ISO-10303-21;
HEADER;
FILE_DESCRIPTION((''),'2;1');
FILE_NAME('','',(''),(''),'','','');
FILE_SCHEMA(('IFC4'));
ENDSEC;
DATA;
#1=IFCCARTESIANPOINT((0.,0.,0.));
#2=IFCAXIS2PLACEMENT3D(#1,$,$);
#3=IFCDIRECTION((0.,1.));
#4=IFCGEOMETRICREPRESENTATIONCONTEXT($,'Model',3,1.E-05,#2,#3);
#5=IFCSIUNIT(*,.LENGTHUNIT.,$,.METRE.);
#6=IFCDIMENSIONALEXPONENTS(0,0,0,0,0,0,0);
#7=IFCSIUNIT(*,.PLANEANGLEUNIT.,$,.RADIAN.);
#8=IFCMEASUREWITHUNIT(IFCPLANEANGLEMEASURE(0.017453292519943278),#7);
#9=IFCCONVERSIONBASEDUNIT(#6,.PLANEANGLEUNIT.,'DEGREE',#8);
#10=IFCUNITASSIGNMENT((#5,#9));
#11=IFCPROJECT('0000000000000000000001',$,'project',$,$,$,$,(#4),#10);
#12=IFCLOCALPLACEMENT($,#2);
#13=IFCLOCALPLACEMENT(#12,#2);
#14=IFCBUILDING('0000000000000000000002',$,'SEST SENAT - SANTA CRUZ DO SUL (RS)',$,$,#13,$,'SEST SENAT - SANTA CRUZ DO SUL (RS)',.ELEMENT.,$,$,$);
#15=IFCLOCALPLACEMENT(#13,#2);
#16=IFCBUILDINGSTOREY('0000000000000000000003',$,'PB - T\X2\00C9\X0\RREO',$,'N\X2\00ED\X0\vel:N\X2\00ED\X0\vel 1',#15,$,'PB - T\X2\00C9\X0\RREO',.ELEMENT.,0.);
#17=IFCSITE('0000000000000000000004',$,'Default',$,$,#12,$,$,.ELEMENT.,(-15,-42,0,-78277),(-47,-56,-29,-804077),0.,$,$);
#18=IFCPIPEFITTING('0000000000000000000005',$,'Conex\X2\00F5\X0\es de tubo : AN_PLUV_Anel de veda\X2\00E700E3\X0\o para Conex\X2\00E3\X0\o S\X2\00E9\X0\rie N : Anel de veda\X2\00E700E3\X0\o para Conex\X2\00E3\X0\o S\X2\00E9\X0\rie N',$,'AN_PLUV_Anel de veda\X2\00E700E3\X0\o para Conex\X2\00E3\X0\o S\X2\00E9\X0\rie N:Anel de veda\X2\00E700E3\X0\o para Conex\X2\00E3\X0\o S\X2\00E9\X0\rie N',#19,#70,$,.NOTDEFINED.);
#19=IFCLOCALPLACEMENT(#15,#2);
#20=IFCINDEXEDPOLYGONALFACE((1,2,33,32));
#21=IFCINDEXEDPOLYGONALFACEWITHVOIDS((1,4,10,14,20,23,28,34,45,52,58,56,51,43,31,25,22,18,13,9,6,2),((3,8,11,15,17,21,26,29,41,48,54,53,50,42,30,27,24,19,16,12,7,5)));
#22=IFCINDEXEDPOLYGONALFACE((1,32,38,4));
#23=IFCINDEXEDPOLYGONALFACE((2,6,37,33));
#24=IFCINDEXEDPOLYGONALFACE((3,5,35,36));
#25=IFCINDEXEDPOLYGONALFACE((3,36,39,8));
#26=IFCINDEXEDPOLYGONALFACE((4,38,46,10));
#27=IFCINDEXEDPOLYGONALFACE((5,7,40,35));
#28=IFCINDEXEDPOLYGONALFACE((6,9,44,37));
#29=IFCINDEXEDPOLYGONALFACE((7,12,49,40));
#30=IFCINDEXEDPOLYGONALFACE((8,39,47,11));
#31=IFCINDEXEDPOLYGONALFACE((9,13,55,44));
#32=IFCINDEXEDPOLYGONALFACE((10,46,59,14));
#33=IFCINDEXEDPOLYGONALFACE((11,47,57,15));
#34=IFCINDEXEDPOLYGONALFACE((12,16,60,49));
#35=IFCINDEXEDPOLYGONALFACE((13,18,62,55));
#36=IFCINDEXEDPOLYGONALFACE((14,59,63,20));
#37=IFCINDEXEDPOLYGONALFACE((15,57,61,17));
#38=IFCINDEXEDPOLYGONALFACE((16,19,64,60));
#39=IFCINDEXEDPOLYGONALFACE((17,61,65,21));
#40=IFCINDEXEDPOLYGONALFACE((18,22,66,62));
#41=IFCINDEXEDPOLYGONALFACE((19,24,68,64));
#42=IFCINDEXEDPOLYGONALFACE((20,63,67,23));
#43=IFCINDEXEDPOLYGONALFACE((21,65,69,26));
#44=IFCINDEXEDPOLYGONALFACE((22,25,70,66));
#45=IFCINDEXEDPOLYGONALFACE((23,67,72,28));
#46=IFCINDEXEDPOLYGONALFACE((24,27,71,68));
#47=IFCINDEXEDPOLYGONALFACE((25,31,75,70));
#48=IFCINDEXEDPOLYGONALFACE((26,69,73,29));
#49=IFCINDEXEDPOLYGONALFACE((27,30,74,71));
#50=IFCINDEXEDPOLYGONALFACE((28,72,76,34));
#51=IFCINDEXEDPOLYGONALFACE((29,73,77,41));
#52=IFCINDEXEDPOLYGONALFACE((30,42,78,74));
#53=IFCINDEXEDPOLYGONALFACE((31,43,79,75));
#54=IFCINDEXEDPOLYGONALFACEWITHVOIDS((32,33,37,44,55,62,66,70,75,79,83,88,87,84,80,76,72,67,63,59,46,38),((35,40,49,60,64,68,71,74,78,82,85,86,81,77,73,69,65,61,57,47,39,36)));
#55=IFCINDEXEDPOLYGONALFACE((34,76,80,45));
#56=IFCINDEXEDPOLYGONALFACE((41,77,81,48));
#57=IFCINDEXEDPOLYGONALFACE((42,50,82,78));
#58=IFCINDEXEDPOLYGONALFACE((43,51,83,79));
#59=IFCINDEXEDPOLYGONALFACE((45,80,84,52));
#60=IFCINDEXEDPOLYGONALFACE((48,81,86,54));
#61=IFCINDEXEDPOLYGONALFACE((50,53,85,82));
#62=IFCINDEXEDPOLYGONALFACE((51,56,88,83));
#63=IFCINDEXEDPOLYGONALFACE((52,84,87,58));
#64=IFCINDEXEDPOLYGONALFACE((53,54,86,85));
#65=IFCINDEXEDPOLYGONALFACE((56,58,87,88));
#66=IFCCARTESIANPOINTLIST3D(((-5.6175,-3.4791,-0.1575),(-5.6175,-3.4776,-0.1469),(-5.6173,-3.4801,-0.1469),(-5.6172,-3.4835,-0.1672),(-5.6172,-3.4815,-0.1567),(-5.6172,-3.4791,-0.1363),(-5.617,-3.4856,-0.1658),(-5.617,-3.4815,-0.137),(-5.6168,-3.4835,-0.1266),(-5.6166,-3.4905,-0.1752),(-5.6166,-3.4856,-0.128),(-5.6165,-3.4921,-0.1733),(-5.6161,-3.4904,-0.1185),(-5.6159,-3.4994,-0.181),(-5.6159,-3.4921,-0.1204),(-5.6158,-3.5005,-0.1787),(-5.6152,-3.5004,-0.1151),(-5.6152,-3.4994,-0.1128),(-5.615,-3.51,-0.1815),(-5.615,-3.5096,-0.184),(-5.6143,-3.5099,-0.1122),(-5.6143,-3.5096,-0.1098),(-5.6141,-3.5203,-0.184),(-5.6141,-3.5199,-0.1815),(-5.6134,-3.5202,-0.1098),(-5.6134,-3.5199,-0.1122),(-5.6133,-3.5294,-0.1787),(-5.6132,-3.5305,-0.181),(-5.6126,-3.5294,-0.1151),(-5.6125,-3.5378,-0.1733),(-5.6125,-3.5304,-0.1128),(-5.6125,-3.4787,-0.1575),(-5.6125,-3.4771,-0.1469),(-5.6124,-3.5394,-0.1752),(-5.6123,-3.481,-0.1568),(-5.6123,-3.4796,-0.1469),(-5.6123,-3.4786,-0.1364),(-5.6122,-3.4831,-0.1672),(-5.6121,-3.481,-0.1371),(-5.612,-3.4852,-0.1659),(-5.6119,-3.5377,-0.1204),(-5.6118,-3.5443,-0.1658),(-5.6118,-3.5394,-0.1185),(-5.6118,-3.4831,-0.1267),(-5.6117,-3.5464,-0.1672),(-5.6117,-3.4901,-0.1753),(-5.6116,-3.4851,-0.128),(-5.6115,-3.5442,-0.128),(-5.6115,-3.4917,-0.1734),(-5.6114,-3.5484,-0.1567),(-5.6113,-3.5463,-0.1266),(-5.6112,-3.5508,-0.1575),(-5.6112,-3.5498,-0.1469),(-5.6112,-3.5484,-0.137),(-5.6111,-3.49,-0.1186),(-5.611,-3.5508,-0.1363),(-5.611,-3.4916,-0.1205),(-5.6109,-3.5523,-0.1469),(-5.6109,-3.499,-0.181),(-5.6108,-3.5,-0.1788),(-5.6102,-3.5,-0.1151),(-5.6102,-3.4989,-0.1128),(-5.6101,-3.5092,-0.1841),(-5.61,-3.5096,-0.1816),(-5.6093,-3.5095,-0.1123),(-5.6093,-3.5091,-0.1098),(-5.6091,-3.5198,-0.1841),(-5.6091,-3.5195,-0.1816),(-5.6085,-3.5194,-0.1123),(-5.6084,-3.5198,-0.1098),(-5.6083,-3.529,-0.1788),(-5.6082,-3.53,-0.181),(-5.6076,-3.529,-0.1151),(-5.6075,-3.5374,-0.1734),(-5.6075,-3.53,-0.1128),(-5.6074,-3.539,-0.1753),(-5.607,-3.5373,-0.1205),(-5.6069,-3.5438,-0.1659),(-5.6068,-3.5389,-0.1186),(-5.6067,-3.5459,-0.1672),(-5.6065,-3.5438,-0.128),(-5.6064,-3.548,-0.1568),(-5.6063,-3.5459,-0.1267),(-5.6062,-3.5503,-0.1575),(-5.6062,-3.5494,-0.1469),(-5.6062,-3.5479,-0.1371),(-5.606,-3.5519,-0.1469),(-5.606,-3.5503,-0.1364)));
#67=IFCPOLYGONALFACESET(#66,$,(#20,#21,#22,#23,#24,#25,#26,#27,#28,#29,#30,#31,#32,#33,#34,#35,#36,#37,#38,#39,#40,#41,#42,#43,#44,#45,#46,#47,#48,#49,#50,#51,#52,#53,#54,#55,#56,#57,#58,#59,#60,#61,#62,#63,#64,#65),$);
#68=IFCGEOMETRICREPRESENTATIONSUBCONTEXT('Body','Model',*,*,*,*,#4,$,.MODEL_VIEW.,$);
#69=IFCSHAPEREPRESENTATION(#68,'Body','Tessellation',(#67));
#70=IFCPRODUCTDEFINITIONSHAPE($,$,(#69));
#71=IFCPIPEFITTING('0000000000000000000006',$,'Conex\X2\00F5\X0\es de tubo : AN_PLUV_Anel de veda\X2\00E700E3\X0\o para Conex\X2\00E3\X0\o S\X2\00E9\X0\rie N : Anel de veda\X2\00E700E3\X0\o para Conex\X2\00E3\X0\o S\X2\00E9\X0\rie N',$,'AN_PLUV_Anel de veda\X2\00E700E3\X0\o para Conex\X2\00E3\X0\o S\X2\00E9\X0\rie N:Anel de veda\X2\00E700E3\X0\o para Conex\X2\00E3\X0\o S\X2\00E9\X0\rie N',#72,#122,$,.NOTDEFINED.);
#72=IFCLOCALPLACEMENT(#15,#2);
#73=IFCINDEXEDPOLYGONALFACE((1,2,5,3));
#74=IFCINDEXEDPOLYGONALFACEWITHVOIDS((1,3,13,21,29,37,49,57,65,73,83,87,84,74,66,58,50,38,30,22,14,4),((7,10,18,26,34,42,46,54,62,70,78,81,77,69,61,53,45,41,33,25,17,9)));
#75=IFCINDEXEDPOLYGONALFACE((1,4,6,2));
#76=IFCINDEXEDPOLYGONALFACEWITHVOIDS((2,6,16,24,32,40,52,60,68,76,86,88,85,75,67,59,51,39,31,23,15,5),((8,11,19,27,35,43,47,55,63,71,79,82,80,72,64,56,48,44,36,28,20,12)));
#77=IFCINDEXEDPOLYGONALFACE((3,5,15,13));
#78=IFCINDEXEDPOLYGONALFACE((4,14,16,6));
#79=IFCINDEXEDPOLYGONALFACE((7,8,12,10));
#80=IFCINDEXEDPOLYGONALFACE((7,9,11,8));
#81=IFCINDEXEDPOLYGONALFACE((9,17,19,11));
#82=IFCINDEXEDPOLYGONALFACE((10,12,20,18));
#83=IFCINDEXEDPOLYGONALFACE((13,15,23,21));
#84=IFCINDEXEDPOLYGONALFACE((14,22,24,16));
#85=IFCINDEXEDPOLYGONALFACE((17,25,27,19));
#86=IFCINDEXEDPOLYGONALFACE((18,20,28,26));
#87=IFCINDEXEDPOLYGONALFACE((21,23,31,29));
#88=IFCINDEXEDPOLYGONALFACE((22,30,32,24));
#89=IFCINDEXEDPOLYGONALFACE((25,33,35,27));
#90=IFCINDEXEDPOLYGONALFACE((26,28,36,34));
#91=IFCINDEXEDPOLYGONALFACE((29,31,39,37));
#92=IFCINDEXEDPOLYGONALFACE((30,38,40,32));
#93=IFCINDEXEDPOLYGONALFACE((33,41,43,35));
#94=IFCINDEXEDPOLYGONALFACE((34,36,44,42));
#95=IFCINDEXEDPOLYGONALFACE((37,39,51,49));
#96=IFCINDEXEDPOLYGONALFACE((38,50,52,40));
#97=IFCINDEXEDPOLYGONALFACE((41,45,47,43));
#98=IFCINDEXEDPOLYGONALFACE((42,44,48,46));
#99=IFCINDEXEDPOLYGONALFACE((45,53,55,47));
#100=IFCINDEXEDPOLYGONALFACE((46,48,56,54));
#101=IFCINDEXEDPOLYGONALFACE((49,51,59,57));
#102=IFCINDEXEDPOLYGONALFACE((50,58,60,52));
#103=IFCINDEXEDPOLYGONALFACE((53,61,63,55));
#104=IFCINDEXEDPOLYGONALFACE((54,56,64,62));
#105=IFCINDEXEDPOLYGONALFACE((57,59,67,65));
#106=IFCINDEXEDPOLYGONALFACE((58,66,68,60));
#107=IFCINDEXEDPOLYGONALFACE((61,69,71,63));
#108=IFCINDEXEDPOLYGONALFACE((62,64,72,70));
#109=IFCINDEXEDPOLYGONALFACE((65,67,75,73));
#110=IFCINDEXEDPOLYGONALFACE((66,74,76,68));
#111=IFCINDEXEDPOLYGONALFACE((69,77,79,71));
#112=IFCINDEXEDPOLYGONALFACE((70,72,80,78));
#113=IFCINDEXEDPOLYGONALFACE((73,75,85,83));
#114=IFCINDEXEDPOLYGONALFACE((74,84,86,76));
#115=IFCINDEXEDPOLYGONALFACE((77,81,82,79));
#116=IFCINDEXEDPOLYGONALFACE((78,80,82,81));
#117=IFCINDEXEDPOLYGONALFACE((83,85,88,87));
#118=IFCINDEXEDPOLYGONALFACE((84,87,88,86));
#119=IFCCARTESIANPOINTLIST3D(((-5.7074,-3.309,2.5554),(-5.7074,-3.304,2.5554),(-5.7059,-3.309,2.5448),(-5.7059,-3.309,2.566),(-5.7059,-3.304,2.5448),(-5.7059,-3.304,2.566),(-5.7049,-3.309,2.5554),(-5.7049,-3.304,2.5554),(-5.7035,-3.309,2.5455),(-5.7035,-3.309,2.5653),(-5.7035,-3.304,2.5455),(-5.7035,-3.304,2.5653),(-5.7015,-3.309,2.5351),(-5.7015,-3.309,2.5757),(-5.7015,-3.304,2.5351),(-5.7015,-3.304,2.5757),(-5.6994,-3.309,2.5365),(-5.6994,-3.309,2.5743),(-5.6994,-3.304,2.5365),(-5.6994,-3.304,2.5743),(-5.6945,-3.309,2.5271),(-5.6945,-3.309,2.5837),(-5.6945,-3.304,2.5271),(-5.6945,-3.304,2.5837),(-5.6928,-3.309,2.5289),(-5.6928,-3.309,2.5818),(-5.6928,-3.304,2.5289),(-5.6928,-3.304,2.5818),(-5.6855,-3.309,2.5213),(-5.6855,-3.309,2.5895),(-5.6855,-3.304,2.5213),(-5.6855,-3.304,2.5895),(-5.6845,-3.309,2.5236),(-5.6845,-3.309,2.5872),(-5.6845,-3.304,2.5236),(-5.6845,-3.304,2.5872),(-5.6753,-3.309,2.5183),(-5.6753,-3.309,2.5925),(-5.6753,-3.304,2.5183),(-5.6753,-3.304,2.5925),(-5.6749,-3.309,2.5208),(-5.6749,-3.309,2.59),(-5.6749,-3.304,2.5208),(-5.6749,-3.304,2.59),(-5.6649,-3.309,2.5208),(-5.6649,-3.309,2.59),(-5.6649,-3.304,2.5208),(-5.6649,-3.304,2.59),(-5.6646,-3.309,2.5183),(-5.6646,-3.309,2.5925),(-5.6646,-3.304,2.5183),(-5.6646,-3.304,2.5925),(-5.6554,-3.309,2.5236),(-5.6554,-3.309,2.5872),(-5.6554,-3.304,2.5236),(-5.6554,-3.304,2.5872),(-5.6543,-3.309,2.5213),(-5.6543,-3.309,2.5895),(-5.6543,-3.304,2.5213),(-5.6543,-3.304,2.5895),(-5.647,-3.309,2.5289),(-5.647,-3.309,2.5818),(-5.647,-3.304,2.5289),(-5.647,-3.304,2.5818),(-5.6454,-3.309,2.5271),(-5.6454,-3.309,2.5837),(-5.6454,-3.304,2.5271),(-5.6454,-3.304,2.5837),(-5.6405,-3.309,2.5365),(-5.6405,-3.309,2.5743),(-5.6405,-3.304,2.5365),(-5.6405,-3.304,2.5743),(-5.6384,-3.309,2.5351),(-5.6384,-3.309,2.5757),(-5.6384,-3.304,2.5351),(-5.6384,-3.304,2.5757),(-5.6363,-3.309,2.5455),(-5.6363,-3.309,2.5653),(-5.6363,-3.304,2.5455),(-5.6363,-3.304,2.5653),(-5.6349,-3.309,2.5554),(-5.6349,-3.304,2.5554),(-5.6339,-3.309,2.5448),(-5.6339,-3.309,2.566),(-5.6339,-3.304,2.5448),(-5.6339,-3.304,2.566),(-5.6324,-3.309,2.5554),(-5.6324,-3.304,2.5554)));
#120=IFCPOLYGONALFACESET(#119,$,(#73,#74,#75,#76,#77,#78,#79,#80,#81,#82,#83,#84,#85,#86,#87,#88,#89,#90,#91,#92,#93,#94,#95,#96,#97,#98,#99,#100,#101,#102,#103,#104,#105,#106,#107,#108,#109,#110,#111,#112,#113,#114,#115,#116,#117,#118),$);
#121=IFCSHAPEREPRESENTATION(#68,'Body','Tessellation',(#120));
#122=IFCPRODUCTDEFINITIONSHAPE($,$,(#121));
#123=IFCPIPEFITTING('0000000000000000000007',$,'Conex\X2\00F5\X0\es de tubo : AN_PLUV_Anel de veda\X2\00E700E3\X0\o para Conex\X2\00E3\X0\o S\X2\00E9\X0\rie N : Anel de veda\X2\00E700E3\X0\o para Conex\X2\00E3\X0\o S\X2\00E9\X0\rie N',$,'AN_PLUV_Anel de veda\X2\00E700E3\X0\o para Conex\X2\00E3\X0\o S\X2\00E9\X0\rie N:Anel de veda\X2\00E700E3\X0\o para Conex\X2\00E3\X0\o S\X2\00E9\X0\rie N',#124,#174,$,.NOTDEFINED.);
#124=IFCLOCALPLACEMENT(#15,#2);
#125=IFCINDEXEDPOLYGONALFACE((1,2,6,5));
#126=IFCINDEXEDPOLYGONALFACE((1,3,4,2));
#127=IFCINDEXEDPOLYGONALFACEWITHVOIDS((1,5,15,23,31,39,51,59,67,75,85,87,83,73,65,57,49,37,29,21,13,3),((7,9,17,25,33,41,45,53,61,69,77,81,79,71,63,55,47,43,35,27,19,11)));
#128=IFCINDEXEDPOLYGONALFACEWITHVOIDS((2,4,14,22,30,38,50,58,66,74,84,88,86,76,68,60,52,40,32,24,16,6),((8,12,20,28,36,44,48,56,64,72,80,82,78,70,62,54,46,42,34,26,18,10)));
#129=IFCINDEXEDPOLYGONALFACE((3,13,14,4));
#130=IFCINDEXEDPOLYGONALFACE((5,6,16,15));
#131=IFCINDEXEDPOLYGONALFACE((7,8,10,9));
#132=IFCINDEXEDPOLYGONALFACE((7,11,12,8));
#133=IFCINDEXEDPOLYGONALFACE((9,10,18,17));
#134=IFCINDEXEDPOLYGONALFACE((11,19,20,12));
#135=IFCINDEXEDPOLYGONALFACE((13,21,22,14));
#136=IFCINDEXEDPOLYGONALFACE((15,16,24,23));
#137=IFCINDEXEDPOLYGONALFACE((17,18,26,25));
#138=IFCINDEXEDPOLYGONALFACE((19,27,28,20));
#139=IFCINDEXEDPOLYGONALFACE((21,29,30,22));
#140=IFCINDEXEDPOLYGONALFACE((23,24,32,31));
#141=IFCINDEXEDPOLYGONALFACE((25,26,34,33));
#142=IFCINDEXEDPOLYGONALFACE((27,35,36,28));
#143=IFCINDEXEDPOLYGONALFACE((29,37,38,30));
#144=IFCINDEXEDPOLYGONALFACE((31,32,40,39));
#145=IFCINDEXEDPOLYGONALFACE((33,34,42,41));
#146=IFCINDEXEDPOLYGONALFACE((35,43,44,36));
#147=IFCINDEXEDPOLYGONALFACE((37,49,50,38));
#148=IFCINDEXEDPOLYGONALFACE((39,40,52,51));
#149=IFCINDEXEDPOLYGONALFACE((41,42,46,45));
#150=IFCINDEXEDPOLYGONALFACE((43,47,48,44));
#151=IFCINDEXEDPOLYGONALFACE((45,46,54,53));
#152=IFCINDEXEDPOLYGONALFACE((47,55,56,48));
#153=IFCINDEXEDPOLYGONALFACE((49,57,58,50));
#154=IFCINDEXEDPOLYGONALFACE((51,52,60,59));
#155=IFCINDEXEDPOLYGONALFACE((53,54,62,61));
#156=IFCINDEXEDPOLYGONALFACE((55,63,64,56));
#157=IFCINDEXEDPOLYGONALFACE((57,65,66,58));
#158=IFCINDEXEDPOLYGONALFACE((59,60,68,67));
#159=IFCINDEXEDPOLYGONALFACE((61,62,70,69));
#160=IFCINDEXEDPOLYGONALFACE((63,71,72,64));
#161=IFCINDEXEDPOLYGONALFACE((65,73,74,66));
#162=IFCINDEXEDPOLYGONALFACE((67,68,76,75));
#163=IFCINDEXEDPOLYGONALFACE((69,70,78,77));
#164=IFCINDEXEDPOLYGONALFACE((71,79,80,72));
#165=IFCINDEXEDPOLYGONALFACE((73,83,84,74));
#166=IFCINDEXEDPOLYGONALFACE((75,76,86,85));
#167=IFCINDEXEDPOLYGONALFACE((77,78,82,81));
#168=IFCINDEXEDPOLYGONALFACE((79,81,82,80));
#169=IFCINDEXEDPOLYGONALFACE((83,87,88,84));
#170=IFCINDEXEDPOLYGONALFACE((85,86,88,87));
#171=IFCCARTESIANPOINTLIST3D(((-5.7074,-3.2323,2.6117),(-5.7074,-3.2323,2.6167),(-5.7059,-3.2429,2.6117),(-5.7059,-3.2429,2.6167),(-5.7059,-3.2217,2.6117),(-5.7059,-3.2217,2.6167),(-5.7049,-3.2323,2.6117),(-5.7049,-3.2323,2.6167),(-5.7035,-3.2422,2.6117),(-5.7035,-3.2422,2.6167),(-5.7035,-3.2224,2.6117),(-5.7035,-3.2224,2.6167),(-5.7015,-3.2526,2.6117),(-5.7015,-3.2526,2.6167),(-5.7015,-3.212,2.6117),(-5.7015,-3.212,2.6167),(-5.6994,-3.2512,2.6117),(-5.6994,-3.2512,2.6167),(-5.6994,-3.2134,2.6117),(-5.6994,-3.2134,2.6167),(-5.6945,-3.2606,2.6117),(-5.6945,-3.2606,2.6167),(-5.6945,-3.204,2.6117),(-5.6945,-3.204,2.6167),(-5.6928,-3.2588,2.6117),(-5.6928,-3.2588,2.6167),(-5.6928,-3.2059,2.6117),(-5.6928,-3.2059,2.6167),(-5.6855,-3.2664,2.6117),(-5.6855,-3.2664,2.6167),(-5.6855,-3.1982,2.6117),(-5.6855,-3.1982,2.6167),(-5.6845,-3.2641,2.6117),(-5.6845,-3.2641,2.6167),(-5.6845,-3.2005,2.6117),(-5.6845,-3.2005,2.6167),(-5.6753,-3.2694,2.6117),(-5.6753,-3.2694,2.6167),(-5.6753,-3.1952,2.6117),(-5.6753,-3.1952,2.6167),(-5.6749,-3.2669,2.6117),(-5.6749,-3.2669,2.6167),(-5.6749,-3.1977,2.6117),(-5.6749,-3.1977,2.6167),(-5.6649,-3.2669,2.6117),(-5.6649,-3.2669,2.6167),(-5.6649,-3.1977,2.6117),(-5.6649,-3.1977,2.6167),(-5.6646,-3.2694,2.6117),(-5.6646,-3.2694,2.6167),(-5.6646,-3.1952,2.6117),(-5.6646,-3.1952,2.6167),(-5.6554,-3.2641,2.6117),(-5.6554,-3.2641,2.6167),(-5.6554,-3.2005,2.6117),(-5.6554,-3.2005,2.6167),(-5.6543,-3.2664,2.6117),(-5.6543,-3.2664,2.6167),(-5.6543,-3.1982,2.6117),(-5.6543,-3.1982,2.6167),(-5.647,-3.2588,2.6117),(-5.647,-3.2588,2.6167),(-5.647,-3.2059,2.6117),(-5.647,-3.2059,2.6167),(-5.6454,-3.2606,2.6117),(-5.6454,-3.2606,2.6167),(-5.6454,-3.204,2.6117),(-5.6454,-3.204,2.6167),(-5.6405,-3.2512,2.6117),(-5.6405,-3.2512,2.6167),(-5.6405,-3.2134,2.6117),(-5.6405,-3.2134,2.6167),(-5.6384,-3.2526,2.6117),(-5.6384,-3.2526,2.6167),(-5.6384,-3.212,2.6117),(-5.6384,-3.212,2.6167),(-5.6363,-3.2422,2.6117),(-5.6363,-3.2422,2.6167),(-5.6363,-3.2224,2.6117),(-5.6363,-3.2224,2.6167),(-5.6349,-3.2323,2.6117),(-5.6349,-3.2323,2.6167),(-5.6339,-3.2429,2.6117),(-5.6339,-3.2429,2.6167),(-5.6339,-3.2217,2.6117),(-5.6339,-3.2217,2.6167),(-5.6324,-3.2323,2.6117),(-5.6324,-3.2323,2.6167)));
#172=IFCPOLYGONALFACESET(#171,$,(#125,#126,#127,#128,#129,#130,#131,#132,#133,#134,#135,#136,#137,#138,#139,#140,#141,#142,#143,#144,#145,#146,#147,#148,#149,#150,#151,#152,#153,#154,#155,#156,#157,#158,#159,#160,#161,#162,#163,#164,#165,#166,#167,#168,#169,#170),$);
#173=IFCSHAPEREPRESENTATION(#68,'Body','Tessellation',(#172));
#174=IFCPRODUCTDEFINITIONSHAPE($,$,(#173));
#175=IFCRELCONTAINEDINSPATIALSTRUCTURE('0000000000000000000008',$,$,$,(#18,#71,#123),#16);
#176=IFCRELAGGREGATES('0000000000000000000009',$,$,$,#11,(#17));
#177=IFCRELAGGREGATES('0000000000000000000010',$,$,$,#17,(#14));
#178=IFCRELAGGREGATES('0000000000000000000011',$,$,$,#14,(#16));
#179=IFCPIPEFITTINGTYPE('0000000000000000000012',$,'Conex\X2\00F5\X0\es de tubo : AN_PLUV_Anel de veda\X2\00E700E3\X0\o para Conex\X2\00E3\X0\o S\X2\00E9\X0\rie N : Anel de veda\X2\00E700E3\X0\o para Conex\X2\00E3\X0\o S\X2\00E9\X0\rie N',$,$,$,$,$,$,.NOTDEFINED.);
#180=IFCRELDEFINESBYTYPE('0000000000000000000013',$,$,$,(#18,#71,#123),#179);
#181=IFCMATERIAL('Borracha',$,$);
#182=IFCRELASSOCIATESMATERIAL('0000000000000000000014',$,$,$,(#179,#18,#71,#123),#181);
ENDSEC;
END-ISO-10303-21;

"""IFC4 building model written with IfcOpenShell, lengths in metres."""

from ifc_helpers import new_model, entity, si_unit, converted_unit, direction, frame, origin, place, context, subcontext, project, spatial, arc, indexed_curve, outline, extrude, source, transform, mapped, material, type_object, type_shapes, element, save


model = new_model("IFC4")

# Units and contexts
model_context = context("Model", 3, precision=1e-05, world=origin(), true_north=direction((0.0, 1.0)))
body_context = subcontext(model_context, "Body", "Model", "MODEL_VIEW")
ifc_project = project(units=[si_unit("LENGTHUNIT", "METRE"), converted_unit("PLANEANGLEUNIT", "DEGREE", entity("IfcPlaneAngleMeasure", 0.017453292519943278), si_unit("PLANEANGLEUNIT", "RADIAN"), dimensions=[0, 0, 0, 0, 0, 0, 0])], contexts=[model_context])

# Site, building, storey
site_placement = place(None, origin())
site = spatial("IfcSite", under=ifc_project, at=site_placement, Name="Default", CompositionType="ELEMENT", RefLatitude=(-15, -42, 0, -78277), RefLongitude=(-47, -56, -29, -804077), RefElevation=0.0)
building_placement = place(site_placement, origin())
building = spatial("IfcBuilding", under=site, at=building_placement, Name="SEST SENAT - SANTA CRUZ DO SUL (RS)", LongName="SEST SENAT - SANTA CRUZ DO SUL (RS)", CompositionType="ELEMENT")
storey_placement = place(building_placement, origin())
storey = spatial("IfcBuildingStorey", under=building, at=storey_placement, Name="PB - TÉRREO", ObjectType="Nível:Nível 1", LongName="PB - TÉRREO", CompositionType="ELEMENT", Elevation=0.0)

# Shared definitions
ifc_material_1 = material(Name="Borracha")

# Pipe fittings
pipe_fitting_type_1 = type_object("IfcPipeFittingType", Name="Conexões de tubo : AN_PLUV_Anel de vedação para Conexão Série N : Anel de vedação para Conexão Série N", PredefinedType="NOTDEFINED", material=ifc_material_1)
shared_shape_1 = source(origin(), body_context, "Body", "SweptSolid", [
    extrude(outline(indexed_curve([(-0.0375, 0.0), (0.0, -0.0375), (0.0375, 0.0), (0.0, 0.0375)], segments=[arc(1, 2, 3), arc(3, 4, 1)], self_intersect=False), holes=[indexed_curve([(-0.035, 0.0), (0.0, 0.035), (0.035, 0.0), (0.0, -0.035)], segments=[arc(1, 2, 3), arc(3, 4, 1)], self_intersect=False)]), frame((0.0, 0.0, -0.005)), (0.0, 0.0, 1.0), 0.005),
])
type_shapes(pipe_fitting_type_1, [shared_shape_1])
for number, where, z_axis, x_axis, name in (
    (1, (-5.6142, -3.5149, -0.1469), (-0.996145, -0.087156, 0.009961), (0.08716, -0.996194, 0.0), "Conexões de tubo : AN_PLUV_Anel de vedação para Conexão Série N : Anel de vedação para Conexão Série N"),
    (2, (-5.6699, -3.309, 2.5554), (0.0, -1.0, 0.0), (1.0, 0.0, 0.0), "Conexões de tubo : AN_PLUV_Anel de vedação para Conexão Série N : Anel de vedação para Conexão Série N"),
    (3, (-5.6699, -3.2323, 2.6117), (0.0, 0.0, -1.0), (1.0, 0.0, 0.0), "Conexões de tubo : AN_PLUV_Anel de vedação para Conexão Série N : Anel de vedação para Conexão Série N"),
):
    element("IfcPipeFitting", number, at=place(storey_placement, frame(where, z_axis=z_axis, x_axis=x_axis)), inside=storey, type_object=pipe_fitting_type_1, material=ifc_material_1, Name=name, ObjectType="AN_PLUV_Anel de vedação para Conexão Série N:Anel de vedação para Conexão Série N", PredefinedType="NOTDEFINED", context=body_context, shape_type="MappedRepresentation", body=[
        mapped(shared_shape_1, transform((0.0, 0.0, 0.0), scale=1.0)),
    ])

save(model, "model.ifc")
